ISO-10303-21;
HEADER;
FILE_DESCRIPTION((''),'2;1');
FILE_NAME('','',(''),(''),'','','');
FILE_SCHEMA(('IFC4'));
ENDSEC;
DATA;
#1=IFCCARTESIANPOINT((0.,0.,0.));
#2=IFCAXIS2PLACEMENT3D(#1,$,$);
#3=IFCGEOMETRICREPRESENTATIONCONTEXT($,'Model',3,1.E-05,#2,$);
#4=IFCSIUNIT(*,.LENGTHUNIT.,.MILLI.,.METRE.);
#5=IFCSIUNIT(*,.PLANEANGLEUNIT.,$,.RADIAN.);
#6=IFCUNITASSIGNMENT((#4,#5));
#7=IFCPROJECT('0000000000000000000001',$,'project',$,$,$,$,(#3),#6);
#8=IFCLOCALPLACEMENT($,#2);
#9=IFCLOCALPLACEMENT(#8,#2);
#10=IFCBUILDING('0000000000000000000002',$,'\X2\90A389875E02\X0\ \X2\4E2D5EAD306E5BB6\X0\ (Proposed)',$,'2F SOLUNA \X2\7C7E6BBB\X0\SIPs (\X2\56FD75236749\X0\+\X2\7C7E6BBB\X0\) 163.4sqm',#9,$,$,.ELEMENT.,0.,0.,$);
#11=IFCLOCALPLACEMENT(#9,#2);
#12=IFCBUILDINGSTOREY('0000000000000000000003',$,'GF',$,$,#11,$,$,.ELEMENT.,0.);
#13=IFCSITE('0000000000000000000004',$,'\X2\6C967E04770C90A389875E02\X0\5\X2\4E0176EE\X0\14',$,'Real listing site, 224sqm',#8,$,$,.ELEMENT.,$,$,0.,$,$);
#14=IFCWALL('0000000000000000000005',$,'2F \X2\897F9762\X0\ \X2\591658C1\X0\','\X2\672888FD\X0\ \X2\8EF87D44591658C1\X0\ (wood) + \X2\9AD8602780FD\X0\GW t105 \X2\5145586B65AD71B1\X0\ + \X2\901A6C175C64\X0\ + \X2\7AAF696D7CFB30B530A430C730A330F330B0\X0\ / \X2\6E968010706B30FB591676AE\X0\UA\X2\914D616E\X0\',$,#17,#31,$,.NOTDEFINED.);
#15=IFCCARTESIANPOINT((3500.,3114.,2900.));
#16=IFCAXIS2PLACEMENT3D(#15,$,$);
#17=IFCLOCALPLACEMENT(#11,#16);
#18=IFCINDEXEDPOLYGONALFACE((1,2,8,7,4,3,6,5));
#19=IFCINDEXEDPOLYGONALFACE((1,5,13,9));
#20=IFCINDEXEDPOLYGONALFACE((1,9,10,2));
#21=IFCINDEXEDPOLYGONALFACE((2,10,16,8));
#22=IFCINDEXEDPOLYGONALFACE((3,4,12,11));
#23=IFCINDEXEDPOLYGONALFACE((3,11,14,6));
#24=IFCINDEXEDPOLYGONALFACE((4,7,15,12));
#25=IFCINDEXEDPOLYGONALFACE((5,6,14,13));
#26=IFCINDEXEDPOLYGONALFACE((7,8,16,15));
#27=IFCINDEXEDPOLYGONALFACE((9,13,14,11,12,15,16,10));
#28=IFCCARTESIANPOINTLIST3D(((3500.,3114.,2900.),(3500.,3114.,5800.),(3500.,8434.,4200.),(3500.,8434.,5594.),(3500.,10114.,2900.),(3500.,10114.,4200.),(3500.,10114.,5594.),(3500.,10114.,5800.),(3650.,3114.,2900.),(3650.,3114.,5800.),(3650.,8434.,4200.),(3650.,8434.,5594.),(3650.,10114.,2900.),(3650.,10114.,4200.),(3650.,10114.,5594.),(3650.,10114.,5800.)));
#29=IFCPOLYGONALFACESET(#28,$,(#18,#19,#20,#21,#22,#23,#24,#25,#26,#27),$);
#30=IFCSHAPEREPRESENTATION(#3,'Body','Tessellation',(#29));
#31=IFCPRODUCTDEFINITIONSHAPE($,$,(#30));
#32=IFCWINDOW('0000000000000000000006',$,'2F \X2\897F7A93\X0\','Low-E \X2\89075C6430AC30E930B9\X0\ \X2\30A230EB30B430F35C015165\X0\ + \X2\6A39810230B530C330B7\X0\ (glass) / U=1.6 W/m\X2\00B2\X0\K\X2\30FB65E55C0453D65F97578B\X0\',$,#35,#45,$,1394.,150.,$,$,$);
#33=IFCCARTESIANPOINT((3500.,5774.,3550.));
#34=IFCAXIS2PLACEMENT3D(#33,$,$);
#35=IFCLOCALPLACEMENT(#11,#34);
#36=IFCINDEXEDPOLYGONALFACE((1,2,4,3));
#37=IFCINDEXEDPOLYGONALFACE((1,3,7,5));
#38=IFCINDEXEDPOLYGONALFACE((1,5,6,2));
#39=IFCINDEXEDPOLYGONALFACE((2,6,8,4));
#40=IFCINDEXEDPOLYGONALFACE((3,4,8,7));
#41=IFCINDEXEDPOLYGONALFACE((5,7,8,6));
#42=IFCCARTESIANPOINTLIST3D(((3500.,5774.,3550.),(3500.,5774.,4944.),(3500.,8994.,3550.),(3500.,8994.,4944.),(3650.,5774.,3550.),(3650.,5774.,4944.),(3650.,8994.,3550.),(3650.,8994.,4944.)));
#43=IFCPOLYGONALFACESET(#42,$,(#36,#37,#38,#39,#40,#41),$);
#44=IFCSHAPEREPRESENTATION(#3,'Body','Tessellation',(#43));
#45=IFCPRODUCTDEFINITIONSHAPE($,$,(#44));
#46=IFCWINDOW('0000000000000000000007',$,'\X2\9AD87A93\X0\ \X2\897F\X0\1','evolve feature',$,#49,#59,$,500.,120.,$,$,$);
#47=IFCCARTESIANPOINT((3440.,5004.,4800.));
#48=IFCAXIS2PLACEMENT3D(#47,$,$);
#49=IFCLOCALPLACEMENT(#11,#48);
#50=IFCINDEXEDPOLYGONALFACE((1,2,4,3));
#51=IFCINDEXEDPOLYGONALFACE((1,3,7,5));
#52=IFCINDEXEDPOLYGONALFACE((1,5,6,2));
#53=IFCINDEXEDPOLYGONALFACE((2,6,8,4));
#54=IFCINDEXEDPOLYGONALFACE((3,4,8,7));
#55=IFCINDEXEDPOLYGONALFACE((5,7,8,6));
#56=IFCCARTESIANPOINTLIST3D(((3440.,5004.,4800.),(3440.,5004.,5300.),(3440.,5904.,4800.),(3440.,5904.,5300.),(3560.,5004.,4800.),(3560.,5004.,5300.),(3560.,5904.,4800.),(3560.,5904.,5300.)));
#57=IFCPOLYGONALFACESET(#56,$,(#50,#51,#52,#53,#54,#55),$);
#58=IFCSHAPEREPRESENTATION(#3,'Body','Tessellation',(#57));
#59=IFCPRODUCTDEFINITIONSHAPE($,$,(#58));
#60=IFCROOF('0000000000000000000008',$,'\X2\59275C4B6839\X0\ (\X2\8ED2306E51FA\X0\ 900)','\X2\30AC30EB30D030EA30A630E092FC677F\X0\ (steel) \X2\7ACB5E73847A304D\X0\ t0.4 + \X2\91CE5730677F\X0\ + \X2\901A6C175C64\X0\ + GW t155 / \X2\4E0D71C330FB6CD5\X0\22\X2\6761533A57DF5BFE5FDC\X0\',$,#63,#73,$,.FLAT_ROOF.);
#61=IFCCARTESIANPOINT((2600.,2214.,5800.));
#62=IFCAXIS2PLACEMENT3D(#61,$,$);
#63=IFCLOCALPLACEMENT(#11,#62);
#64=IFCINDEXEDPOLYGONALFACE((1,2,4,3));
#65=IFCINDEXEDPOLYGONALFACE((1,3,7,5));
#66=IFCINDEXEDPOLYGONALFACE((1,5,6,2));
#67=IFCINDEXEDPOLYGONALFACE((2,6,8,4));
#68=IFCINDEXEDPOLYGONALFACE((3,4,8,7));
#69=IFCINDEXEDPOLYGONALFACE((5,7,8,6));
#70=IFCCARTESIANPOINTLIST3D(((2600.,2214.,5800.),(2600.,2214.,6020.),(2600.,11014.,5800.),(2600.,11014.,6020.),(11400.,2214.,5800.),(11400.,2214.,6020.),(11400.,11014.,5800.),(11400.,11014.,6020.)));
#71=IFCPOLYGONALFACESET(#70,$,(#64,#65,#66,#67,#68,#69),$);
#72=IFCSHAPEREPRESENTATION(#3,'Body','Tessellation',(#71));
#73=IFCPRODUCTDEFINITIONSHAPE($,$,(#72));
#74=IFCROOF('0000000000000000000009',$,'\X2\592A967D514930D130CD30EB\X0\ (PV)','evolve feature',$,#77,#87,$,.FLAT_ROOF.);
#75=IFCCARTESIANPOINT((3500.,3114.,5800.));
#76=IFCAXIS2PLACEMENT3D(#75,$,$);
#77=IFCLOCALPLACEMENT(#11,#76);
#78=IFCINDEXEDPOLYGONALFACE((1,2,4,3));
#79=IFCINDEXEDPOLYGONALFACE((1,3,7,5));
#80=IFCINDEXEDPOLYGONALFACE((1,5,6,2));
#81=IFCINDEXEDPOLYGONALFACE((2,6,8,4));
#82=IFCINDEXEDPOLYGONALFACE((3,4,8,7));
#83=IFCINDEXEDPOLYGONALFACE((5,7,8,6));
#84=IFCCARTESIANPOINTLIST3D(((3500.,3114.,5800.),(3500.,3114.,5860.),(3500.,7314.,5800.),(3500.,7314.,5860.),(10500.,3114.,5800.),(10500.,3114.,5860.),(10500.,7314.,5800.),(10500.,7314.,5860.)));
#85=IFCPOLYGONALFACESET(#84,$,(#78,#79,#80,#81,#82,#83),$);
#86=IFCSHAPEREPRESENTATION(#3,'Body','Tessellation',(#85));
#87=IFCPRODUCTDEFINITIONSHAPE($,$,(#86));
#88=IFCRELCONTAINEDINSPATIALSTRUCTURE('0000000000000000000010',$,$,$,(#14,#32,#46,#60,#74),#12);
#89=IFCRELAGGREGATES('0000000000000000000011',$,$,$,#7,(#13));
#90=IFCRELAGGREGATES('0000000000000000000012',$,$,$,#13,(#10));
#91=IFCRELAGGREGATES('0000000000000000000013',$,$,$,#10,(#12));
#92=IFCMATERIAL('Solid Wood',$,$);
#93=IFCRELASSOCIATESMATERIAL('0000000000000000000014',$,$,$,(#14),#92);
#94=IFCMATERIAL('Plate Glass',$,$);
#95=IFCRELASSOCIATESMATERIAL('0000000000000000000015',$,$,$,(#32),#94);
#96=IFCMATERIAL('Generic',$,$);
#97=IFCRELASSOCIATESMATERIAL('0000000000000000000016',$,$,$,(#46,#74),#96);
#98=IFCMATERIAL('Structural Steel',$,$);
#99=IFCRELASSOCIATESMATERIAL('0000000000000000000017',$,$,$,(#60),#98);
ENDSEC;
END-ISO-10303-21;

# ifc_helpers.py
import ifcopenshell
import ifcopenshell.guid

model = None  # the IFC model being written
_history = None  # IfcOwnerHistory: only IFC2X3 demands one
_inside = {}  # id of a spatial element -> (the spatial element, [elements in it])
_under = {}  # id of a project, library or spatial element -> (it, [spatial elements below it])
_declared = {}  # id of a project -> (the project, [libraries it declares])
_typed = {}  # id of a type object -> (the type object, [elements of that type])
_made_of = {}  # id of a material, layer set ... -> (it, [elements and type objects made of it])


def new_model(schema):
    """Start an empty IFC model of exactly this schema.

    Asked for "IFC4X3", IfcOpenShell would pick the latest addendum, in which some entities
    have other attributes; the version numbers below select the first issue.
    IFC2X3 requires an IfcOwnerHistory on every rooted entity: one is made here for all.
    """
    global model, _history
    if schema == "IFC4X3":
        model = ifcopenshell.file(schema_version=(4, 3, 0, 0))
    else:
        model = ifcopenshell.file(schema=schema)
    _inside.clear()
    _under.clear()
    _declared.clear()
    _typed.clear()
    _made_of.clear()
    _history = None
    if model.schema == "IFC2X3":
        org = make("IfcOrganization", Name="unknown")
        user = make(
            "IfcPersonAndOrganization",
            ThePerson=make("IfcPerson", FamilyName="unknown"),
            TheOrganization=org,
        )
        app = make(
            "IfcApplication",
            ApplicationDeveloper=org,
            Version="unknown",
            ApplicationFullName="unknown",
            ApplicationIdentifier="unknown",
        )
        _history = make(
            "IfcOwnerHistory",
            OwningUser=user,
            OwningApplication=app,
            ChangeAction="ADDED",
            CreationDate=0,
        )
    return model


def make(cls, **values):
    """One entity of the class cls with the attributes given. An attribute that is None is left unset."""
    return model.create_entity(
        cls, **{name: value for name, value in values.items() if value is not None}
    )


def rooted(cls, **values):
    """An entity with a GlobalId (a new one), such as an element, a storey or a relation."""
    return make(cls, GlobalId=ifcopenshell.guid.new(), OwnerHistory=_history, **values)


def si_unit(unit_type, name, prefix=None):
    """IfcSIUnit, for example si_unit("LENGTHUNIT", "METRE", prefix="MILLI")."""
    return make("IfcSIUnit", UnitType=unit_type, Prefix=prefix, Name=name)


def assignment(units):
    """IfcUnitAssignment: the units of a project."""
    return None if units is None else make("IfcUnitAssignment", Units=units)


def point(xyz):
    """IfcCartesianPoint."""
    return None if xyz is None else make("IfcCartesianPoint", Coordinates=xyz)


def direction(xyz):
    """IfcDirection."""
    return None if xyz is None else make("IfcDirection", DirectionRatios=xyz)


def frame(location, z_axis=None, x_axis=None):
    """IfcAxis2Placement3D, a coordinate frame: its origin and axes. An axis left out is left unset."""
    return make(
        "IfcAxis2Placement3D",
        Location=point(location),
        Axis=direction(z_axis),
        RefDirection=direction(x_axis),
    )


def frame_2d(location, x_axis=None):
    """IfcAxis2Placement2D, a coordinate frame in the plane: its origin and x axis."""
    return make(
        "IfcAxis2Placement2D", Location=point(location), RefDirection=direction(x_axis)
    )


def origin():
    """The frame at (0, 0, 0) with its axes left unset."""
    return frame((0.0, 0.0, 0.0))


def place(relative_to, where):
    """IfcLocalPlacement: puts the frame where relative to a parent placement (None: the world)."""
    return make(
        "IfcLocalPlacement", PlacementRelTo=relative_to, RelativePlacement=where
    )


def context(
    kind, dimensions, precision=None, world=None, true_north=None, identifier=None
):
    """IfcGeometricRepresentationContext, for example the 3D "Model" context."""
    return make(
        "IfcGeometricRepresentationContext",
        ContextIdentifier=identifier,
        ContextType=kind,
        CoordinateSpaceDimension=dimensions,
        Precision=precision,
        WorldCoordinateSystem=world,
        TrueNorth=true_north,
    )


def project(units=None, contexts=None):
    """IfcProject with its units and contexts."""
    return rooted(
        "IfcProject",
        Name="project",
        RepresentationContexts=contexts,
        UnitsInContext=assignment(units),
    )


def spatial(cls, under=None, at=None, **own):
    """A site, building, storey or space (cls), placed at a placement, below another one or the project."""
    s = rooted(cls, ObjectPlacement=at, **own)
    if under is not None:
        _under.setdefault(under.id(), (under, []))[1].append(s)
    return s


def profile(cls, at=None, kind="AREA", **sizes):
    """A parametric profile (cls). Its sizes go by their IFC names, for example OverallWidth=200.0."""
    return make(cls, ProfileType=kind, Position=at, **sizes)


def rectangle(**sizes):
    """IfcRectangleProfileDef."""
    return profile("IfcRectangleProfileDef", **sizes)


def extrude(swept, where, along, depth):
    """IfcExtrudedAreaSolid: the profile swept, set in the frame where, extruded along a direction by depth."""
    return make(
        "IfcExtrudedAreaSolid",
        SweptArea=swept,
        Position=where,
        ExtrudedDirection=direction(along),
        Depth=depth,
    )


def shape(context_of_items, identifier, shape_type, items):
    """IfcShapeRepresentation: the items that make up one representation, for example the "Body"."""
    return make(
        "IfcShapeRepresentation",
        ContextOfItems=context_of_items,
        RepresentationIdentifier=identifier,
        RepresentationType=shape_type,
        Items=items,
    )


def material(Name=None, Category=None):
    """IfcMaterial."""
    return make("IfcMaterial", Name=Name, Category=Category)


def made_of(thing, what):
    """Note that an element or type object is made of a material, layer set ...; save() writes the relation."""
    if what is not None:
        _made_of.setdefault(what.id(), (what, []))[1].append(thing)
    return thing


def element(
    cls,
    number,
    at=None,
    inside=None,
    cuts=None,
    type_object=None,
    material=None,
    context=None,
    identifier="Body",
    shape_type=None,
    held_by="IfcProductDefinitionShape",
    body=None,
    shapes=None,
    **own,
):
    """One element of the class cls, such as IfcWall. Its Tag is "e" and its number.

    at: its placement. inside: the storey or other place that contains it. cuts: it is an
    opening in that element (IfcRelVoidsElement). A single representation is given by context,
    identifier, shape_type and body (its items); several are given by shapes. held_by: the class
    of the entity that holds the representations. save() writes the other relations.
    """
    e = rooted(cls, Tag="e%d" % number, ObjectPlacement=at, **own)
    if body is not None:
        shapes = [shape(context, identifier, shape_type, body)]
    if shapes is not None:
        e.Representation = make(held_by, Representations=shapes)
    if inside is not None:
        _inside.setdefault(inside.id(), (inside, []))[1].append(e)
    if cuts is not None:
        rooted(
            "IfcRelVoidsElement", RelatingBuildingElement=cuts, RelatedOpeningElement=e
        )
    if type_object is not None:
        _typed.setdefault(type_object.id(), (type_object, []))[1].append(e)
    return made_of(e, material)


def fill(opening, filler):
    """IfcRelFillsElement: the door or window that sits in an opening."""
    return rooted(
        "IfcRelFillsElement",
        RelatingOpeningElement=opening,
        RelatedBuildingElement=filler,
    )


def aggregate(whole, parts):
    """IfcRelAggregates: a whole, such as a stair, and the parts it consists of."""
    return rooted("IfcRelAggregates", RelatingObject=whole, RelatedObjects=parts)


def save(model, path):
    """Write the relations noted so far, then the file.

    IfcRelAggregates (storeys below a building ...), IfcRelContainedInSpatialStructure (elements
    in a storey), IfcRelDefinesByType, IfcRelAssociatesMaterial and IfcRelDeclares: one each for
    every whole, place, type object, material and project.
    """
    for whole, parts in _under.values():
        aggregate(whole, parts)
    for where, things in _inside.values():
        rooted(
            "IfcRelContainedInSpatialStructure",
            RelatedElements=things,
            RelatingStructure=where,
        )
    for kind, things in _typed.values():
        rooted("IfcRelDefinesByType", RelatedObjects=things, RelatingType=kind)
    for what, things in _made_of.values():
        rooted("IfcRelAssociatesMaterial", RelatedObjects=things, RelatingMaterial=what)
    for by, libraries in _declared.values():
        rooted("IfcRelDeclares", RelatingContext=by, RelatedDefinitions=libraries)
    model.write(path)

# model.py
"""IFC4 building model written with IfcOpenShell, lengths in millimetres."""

from ifc_helpers import new_model, si_unit, frame, frame_2d, origin, place, context, project, spatial, rectangle, extrude, material, element, fill, save


model = new_model("IFC4")

# Units and contexts
model_context = context("Model", 3, precision=1e-05, world=origin())
ifc_project = project(units=[si_unit("LENGTHUNIT", "METRE", prefix="MILLI"), si_unit("PLANEANGLEUNIT", "RADIAN")], contexts=[model_context])

# Site, building, storey
site_placement = place(None, origin())
site = spatial("IfcSite", under=ifc_project, at=site_placement, Name="沖縄県那覇市5丁目14", ObjectType="Real listing site, 224sqm", CompositionType="ELEMENT", RefElevation=0.0)
building_placement = place(site_placement, origin())
building = spatial("IfcBuilding", under=site, at=building_placement, Name="那覇市 中庭の家 (Proposed)", ObjectType="2F SOLUNA 籾殻SIPs (国産杉+籾殻) 163.4sqm", CompositionType="ELEMENT", ElevationOfRefHeight=0.0, ElevationOfTerrain=0.0)
storey_placement = place(building_placement, origin())
storey = spatial("IfcBuildingStorey", under=building, at=storey_placement, Name="GF", CompositionType="ELEMENT", Elevation=0.0)

# Shared definitions
ifc_material_1 = material(Name="Solid Wood")
ifc_material_2 = material(Name="Generic")

# Shared definitions
ifc_material_3 = material(Name="Plate Glass")

# Wall, openings, windows
wall_1_placement = place(storey_placement, frame((3500.0, 3114.0, 2900.0)))
wall_1 = element("IfcWall", 1, at=wall_1_placement, inside=storey, material=ifc_material_1, Name="2F 西面 外壁", Description="木製 軸組外壁 (wood) + 高性能GW t105 充填断熱 + 通気層 + 窯業系サイディング / 準耐火・外皮UA配慮", PredefinedType="NOTDEFINED", context=model_context, shape_type="SweptSolid", body=[
    extrude(rectangle(XDim=150.0, YDim=7000.0, at=frame_2d((75.0, 3500.0))), frame((3500.0, 3114.0, 2900.0)), (0.0, 0.0, 1.0), 2900.0),
])
opening_1_placement = place(storey_placement, frame((3500.0, 5774.0, 3550.0)))
opening_1 = element("IfcOpeningElement", 2, at=opening_1_placement, cuts=wall_1, PredefinedType="NOTDEFINED", context=model_context, shape_type="SweptSolid", body=[
    extrude(rectangle(XDim=150.0, YDim=3220.0, at=frame_2d((75.0, 1610.0))), frame((3500.0, 5774.0, 3550.0)), (0.0, 0.0, 1.0), 1394.0),
])
opening_2_placement = place(storey_placement, frame((3440.0, 5004.0, 4800.0)))
opening_2 = element("IfcOpeningElement", 3, at=opening_2_placement, cuts=wall_1, PredefinedType="NOTDEFINED", context=model_context, shape_type="SweptSolid", body=[
    extrude(rectangle(XDim=120.0, YDim=900.0, at=frame_2d((60.0, 450.0))), frame((3440.0, 5004.0, 4800.0)), (0.0, 0.0, 1.0), 500.0),
])
window_1_placement = place(storey_placement, frame((3500.0, 5774.0, 3550.0)))
window_1 = element("IfcWindow", 4, at=window_1_placement, inside=storey, material=ifc_material_3, Name="2F 西窓", Description="Low-E 複層ガラス アルゴン封入 + 樹脂サッシ (glass) / U=1.6 W/m²K・日射取得型", OverallHeight=1394.0, OverallWidth=150.0, context=model_context, shape_type="SweptSolid", body=[
    extrude(rectangle(XDim=150.0, YDim=3220.0, at=frame_2d((75.0, 1610.0))), frame((3500.0, 5774.0, 3550.0)), (0.0, 0.0, 1.0), 1394.0),
])
fill(opening_1, window_1)
window_2_placement = place(storey_placement, frame((3440.0, 5004.0, 4800.0)))
window_2 = element("IfcWindow", 5, at=window_2_placement, inside=storey, material=ifc_material_2, Name="高窓 西1", Description="evolve feature", OverallHeight=500.0, OverallWidth=120.0, context=model_context, shape_type="SweptSolid", body=[
    extrude(rectangle(XDim=120.0, YDim=900.0, at=frame_2d((60.0, 450.0))), frame((3440.0, 5004.0, 4800.0)), (0.0, 0.0, 1.0), 500.0),
])
fill(opening_2, window_2)

# Roofs
ifc_material_4 = material(Name="Structural Steel")
roof_1_placement = place(storey_placement, frame((2600.0, 2214.0, 5800.0)))
element("IfcRoof", 6, at=roof_1_placement, inside=storey, material=ifc_material_4, Name="大屋根 (軒の出 900)", Description="ガルバリウム鋼板 (steel) 立平葺き t0.4 + 野地板 + 通気層 + GW t155 / 不燃・法22条区域対応", PredefinedType="FLAT_ROOF", context=model_context, shape_type="SweptSolid", body=[
    extrude(rectangle(XDim=8800.0, YDim=8800.0, at=frame_2d((4400.0, 4400.0))), frame((2600.0, 2214.0, 5800.0)), (0.0, 0.0, 1.0), 220.0),
])
roof_2_placement = place(storey_placement, frame((3500.0, 3114.0, 5800.0)))
element("IfcRoof", 7, at=roof_2_placement, inside=storey, material=ifc_material_2, Name="太陽光パネル (PV)", Description="evolve feature", PredefinedType="FLAT_ROOF", context=model_context, shape_type="SweptSolid", body=[
    extrude(rectangle(XDim=7000.0, YDim=4200.0, at=frame_2d((3500.0, 2100.0))), frame((3500.0, 3114.0, 5800.0)), (0.0, 0.0, 1.0), 60.0),
])

save(model, "model.ifc")
